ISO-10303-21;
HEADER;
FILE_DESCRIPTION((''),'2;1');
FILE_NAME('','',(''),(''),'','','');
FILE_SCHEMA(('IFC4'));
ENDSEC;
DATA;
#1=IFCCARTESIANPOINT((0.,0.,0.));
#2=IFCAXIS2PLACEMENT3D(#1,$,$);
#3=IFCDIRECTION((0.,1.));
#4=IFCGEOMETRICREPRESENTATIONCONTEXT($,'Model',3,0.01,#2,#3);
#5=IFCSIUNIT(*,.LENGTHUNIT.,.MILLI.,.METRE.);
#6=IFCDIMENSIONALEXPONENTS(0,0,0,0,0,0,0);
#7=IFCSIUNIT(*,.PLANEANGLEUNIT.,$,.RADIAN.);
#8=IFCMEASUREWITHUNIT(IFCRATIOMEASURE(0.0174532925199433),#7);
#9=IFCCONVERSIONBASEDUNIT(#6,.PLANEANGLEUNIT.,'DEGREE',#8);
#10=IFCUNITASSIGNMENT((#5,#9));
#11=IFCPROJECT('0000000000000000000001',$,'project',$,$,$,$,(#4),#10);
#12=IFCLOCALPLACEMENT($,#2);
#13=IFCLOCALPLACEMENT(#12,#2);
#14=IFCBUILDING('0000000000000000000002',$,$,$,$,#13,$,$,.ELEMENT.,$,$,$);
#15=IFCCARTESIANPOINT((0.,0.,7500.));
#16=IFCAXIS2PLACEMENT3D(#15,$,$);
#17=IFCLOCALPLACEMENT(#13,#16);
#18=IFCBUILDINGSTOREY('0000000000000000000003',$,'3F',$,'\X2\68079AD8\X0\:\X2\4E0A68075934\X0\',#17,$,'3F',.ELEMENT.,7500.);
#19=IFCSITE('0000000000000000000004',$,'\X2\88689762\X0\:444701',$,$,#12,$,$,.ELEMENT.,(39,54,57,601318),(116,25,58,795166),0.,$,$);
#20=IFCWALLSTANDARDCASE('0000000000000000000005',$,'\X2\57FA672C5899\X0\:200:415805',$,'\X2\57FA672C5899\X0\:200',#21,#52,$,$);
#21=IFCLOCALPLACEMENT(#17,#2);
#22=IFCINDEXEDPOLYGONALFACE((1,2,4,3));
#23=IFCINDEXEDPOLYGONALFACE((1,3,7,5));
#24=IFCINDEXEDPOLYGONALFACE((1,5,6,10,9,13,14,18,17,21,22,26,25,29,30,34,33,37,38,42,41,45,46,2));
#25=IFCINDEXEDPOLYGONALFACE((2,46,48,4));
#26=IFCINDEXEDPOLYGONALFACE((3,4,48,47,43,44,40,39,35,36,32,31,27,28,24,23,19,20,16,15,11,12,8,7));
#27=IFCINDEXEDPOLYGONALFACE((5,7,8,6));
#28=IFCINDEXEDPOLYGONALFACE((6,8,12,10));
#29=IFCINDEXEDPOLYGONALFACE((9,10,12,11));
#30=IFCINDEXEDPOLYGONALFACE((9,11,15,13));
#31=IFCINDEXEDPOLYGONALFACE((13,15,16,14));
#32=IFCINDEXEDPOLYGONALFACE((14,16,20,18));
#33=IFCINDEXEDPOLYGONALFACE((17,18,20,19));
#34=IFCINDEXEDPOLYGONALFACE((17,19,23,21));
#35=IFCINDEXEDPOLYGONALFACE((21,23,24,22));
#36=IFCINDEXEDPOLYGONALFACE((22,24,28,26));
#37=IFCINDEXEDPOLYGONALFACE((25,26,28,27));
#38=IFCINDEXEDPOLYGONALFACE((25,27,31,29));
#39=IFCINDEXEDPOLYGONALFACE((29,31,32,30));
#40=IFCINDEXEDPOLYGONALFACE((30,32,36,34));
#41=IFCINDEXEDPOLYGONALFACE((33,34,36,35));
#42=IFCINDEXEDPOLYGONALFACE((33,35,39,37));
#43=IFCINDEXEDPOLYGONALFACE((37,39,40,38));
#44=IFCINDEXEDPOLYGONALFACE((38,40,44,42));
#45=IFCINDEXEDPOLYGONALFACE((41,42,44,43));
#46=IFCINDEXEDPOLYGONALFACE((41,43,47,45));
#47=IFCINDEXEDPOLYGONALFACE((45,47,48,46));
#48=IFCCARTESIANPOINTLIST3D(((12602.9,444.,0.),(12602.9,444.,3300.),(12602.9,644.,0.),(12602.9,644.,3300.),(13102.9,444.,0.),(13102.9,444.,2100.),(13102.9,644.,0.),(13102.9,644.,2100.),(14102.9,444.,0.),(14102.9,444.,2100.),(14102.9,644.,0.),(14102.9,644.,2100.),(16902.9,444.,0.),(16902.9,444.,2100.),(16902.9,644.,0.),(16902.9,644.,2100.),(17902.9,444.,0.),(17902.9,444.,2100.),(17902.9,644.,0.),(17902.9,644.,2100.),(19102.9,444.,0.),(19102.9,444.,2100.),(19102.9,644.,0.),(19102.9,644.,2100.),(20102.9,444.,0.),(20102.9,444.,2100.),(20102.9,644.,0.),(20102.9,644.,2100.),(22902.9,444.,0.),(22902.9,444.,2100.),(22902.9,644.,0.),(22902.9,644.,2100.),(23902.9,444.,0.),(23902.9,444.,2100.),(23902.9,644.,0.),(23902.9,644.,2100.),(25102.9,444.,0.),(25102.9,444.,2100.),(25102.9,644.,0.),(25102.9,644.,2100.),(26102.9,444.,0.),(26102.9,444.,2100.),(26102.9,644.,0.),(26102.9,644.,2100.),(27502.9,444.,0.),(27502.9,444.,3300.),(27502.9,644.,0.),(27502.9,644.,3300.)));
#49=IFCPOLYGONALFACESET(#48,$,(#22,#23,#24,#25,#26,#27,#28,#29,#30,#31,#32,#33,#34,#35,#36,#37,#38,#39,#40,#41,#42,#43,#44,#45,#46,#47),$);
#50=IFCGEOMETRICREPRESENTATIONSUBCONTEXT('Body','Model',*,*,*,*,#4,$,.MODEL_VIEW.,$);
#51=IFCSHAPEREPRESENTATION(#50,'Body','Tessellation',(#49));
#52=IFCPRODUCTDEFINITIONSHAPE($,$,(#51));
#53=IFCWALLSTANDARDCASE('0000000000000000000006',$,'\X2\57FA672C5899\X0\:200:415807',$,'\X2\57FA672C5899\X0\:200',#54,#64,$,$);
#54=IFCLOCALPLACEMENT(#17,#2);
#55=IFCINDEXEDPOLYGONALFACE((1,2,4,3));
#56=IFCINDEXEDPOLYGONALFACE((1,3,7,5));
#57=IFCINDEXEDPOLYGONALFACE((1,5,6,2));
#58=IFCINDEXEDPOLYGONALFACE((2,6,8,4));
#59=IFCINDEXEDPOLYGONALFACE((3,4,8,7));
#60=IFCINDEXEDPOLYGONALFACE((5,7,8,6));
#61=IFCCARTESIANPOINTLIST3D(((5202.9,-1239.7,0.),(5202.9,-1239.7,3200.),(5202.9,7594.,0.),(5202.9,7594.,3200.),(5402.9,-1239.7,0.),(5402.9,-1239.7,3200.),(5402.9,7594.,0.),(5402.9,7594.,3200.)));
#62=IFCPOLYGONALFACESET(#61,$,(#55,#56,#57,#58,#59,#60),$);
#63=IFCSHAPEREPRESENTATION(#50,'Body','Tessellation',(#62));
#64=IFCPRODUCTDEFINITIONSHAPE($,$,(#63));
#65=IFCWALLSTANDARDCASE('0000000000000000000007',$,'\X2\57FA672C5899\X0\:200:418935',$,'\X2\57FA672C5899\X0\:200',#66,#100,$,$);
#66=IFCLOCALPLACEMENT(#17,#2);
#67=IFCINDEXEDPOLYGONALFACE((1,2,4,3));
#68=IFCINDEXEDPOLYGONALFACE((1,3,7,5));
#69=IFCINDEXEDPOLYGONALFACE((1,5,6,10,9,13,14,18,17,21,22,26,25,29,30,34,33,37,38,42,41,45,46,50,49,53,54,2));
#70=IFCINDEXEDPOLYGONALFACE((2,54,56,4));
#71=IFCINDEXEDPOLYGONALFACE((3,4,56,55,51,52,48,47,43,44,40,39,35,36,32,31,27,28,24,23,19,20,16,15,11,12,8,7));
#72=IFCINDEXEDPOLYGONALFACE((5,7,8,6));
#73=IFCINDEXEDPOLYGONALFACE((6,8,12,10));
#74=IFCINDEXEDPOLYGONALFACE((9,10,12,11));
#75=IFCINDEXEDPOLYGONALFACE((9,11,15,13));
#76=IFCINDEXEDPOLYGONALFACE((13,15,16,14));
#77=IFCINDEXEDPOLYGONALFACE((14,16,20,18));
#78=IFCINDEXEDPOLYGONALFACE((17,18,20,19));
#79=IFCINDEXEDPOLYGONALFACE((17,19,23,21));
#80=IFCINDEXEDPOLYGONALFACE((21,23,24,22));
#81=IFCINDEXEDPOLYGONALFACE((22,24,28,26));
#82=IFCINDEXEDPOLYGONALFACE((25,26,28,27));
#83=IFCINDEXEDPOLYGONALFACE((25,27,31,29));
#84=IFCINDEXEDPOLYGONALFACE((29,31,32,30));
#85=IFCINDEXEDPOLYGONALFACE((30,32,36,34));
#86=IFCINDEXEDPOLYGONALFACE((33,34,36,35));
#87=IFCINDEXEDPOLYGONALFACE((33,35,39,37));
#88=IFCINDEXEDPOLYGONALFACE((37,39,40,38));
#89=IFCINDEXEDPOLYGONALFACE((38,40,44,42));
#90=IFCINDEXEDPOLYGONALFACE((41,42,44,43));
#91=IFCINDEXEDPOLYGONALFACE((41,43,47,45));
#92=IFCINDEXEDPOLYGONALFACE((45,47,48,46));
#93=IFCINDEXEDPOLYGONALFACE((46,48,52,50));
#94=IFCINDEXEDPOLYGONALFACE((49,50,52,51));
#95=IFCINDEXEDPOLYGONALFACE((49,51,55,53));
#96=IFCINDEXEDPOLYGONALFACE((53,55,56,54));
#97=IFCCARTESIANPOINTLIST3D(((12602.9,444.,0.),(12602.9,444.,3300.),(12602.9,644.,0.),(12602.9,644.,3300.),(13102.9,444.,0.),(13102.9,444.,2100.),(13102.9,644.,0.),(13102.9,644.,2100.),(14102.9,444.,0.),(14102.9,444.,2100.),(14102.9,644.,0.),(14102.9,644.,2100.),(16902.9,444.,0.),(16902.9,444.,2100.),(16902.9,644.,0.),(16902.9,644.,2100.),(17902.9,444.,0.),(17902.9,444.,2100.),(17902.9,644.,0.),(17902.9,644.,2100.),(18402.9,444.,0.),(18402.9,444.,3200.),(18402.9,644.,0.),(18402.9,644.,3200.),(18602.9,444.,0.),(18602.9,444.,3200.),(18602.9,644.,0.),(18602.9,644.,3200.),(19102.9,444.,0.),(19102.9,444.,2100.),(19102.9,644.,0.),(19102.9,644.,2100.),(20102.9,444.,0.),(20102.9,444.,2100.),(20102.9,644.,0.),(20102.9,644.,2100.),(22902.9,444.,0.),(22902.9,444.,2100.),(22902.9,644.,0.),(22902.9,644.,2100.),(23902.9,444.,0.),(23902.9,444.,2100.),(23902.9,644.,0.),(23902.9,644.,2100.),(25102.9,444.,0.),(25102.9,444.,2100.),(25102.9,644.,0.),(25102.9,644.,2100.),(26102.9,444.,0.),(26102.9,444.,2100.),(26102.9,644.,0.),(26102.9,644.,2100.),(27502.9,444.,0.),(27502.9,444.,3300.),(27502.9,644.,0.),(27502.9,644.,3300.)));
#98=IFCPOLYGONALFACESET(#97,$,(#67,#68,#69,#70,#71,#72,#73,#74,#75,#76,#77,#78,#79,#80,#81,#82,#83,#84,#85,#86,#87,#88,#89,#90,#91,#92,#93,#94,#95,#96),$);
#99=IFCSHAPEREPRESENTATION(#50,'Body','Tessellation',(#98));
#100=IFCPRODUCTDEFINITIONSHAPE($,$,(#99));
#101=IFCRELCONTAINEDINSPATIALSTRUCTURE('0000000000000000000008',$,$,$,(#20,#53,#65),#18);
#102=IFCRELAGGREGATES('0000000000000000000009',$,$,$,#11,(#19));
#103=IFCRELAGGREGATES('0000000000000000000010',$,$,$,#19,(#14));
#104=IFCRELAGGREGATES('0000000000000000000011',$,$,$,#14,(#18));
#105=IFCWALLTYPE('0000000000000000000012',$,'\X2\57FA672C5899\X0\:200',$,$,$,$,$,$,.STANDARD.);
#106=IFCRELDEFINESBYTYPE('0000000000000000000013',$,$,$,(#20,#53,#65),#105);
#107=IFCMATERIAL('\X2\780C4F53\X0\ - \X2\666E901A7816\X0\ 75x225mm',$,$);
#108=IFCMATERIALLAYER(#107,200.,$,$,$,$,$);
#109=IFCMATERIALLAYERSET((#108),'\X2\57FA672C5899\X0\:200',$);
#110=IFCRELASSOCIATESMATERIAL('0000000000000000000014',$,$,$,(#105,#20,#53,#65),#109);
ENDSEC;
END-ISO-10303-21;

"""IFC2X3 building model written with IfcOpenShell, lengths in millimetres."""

from ifc_helpers import new_model, entity, si_unit, converted_unit, direction, frame, frame_2d, origin, place, context, subcontext, project, spatial, polyline, rectangle, extrude, clip, bounded_halfspace, material, layer, layer_set, layer_usage, type_object, element, save


model = new_model("IFC2X3")

# Units and contexts
model_context = context("Model", 3, precision=0.01, world=origin(), true_north=direction((0.0, 1.0)))
body_context = subcontext(model_context, "Body", "Model", "MODEL_VIEW")
ifc_project = project(units=[si_unit("LENGTHUNIT", "METRE", prefix="MILLI"), converted_unit("PLANEANGLEUNIT", "DEGREE", entity("IfcRatioMeasure", 0.0174532925199433), si_unit("PLANEANGLEUNIT", "RADIAN"), dimensions=[0, 0, 0, 0, 0, 0, 0])], contexts=[model_context])

# Site, building, storey
site_placement = place(None, origin())
site = spatial("IfcSite", under=ifc_project, at=site_placement, Name="表面:444701", CompositionType="ELEMENT", RefLatitude=(39, 54, 57, 601318), RefLongitude=(116, 25, 58, 795166), RefElevation=0.0)
building_placement = place(site_placement, origin())
building = spatial("IfcBuilding", under=site, at=building_placement, CompositionType="ELEMENT")
storey_placement = place(building_placement, frame((0.0, 0.0, 7500.0)))
storey = spatial("IfcBuildingStorey", under=building, at=storey_placement, Name="3F", ObjectType="标高:上标头", LongName="3F", CompositionType="ELEMENT", Elevation=7500.0)

# Shared definitions
ifc_material_1 = material(Name="砌体 - 普通砖 75x225mm")

# Wall, openings
ifc_layer_1 = layer(ifc_material_1, 200.0)
ifc_layer_set_1 = layer_set([ifc_layer_1], Name="基本墙:200")
ifc_layer_usage_1 = layer_usage(ifc_layer_set_1, "AXIS2", "NEGATIVE", 100.0)
wall_type_1 = type_object("IfcWallType", Name="基本墙:200", PredefinedType="STANDARD", material=ifc_layer_set_1)
wall_1_placement = place(storey_placement, frame((12602.9, 544.0, 0.0)))
wall_1 = element("IfcWallStandardCase", 1, at=wall_1_placement, inside=storey, type_object=wall_type_1, material=ifc_layer_usage_1, Name="基本墙:200:415805", ObjectType="基本墙:200", context=body_context, shape_type="SweptSolid", body=[
    extrude(rectangle(XDim=14900.0, YDim=200.0, at=frame_2d((7450.0, 0.0), x_axis=(-1.0, 0.0))), origin(), (0.0, 0.0, 1.0), 3300.0),
])
opening_1_placement = place(wall_1_placement, frame((12500.0, -100.0, 0.0)))
element("IfcOpeningElement", 2, at=opening_1_placement, cuts=wall_1, ObjectType="Opening", context=body_context, shape_type="SweptSolid", body=[
    extrude(rectangle(XDim=2100.0, YDim=1000.0, at=frame_2d((1050.0, 500.0), x_axis=(1.0, 0.0))), frame((0.0, 0.0, 0.0), z_axis=(0.0, 1.0, 0.0), x_axis=(0.0, 0.0, 1.0)), (0.0, 0.0, 1.0), 200.0),
])
opening_2_placement = place(wall_1_placement, frame((10300.0, -100.0, 0.0)))
element("IfcOpeningElement", 3, at=opening_2_placement, cuts=wall_1, ObjectType="Opening", context=body_context, shape_type="SweptSolid", body=[
    extrude(rectangle(XDim=2100.0, YDim=1000.0, at=frame_2d((1050.0, 500.0), x_axis=(1.0, 0.0))), frame((0.0, 0.0, 0.0), z_axis=(0.0, 1.0, 0.0), x_axis=(0.0, 0.0, 1.0)), (0.0, 0.0, 1.0), 200.0),
])
opening_3_placement = place(wall_1_placement, frame((6500.0, -100.0, 0.0)))
element("IfcOpeningElement", 4, at=opening_3_placement, cuts=wall_1, ObjectType="Opening", context=body_context, shape_type="SweptSolid", body=[
    extrude(rectangle(XDim=2100.0, YDim=1000.0, at=frame_2d((1050.0, 500.0), x_axis=(1.0, 0.0))), frame((0.0, 0.0, 0.0), z_axis=(0.0, 1.0, 0.0), x_axis=(0.0, 0.0, 1.0)), (0.0, 0.0, 1.0), 200.0),
])
opening_4_placement = place(wall_1_placement, frame((4300.0, -100.0, 0.0)))
element("IfcOpeningElement", 5, at=opening_4_placement, cuts=wall_1, ObjectType="Opening", context=body_context, shape_type="SweptSolid", body=[
    extrude(rectangle(XDim=2100.0, YDim=1000.0, at=frame_2d((1050.0, 500.0), x_axis=(1.0, 0.0))), frame((0.0, 0.0, 0.0), z_axis=(0.0, 1.0, 0.0), x_axis=(0.0, 0.0, 1.0)), (0.0, 0.0, 1.0), 200.0),
])
opening_5_placement = place(wall_1_placement, frame((500.0, -100.0, 0.0)))
element("IfcOpeningElement", 6, at=opening_5_placement, cuts=wall_1, ObjectType="Opening", context=body_context, shape_type="SweptSolid", body=[
    extrude(rectangle(XDim=2100.0, YDim=1000.0, at=frame_2d((1050.0, 500.0), x_axis=(1.0, 0.0))), frame((0.0, 0.0, 0.0), z_axis=(0.0, 1.0, 0.0), x_axis=(0.0, 0.0, 1.0)), (0.0, 0.0, 1.0), 200.0),
])

# Wall
ifc_layer_usage_2 = layer_usage(ifc_layer_set_1, "AXIS2", "NEGATIVE", 100.0)
wall_2_placement = place(storey_placement, frame((5302.9, 7594.0, 0.0), z_axis=(0.0, 0.0, 1.0), x_axis=(0.0, -1.0, 0.0)))
element("IfcWallStandardCase", 7, at=wall_2_placement, inside=storey, type_object=wall_type_1, material=ifc_layer_usage_2, Name="基本墙:200:415807", ObjectType="基本墙:200", context=body_context, shape_type="SweptSolid", body=[
    extrude(rectangle(XDim=8833.7, YDim=200.0, at=frame_2d((4416.9, 0.0), x_axis=(-1.0, 0.0))), origin(), (0.0, 0.0, 1.0), 3200.0),
])

# Wall, openings
ifc_layer_usage_3 = layer_usage(ifc_layer_set_1, "AXIS2", "NEGATIVE", 100.0)
wall_3_placement = place(storey_placement, frame((12602.9, 544.0, 0.0)))
wall_3 = element("IfcWallStandardCase", 8, at=wall_3_placement, inside=storey, type_object=wall_type_1, material=ifc_layer_usage_3, Name="基本墙:200:418935", ObjectType="基本墙:200", context=body_context, shape_type="Clipping", body=[
    clip(extrude(rectangle(XDim=14900.0, YDim=200.0, at=frame_2d((7450.0, 0.0), x_axis=(-1.0, 0.0))), origin(), (0.0, 0.0, 1.0), 3300.0), bounded_halfspace(frame((6000.0, 100.0, 3200.0), z_axis=(0.0, 0.0, 1.0), x_axis=(-1.0, 0.0, 0.0)), True, frame((6000.0, 100.0, 3200.0), z_axis=(0.0, 0.0, 1.0), x_axis=(-1.0, 0.0, 0.0)), polyline([(0.0, 0.0), (200.0, 0.0), (200.0, 200.0), (0.0, 200.0), (0.0, 0.0)]))),
])
opening_6_placement = place(wall_3_placement, frame((12500.0, -100.0, 0.0)))
element("IfcOpeningElement", 9, at=opening_6_placement, cuts=wall_3, ObjectType="Opening", context=body_context, shape_type="SweptSolid", body=[
    extrude(rectangle(XDim=2100.0, YDim=1000.0, at=frame_2d((1050.0, 500.0), x_axis=(1.0, 0.0))), frame((0.0, 0.0, 0.0), z_axis=(0.0, 1.0, 0.0), x_axis=(0.0, 0.0, 1.0)), (0.0, 0.0, 1.0), 200.0),
])
opening_7_placement = place(wall_3_placement, frame((10300.0, -100.0, 0.0)))
element("IfcOpeningElement", 10, at=opening_7_placement, cuts=wall_3, ObjectType="Opening", context=body_context, shape_type="SweptSolid", body=[
    extrude(rectangle(XDim=2100.0, YDim=1000.0, at=frame_2d((1050.0, 500.0), x_axis=(1.0, 0.0))), frame((0.0, 0.0, 0.0), z_axis=(0.0, 1.0, 0.0), x_axis=(0.0, 0.0, 1.0)), (0.0, 0.0, 1.0), 200.0),
])
opening_8_placement = place(wall_3_placement, frame((6500.0, -100.0, 0.0)))
element("IfcOpeningElement", 11, at=opening_8_placement, cuts=wall_3, ObjectType="Opening", context=body_context, shape_type="SweptSolid", body=[
    extrude(rectangle(XDim=2100.0, YDim=1000.0, at=frame_2d((1050.0, 500.0), x_axis=(1.0, 0.0))), frame((0.0, 0.0, 0.0), z_axis=(0.0, 1.0, 0.0), x_axis=(0.0, 0.0, 1.0)), (0.0, 0.0, 1.0), 200.0),
])
opening_9_placement = place(wall_3_placement, frame((4300.0, -100.0, 0.0)))
element("IfcOpeningElement", 12, at=opening_9_placement, cuts=wall_3, ObjectType="Opening", context=body_context, shape_type="SweptSolid", body=[
    extrude(rectangle(XDim=2100.0, YDim=1000.0, at=frame_2d((1050.0, 500.0), x_axis=(1.0, 0.0))), frame((0.0, 0.0, 0.0), z_axis=(0.0, 1.0, 0.0), x_axis=(0.0, 0.0, 1.0)), (0.0, 0.0, 1.0), 200.0),
])
opening_10_placement = place(wall_3_placement, frame((500.0, -100.0, 0.0)))
element("IfcOpeningElement", 13, at=opening_10_placement, cuts=wall_3, ObjectType="Opening", context=body_context, shape_type="SweptSolid", body=[
    extrude(rectangle(XDim=2100.0, YDim=1000.0, at=frame_2d((1050.0, 500.0), x_axis=(1.0, 0.0))), frame((0.0, 0.0, 0.0), z_axis=(0.0, 1.0, 0.0), x_axis=(0.0, 0.0, 1.0)), (0.0, 0.0, 1.0), 200.0),
])

save(model, "model.ifc")
